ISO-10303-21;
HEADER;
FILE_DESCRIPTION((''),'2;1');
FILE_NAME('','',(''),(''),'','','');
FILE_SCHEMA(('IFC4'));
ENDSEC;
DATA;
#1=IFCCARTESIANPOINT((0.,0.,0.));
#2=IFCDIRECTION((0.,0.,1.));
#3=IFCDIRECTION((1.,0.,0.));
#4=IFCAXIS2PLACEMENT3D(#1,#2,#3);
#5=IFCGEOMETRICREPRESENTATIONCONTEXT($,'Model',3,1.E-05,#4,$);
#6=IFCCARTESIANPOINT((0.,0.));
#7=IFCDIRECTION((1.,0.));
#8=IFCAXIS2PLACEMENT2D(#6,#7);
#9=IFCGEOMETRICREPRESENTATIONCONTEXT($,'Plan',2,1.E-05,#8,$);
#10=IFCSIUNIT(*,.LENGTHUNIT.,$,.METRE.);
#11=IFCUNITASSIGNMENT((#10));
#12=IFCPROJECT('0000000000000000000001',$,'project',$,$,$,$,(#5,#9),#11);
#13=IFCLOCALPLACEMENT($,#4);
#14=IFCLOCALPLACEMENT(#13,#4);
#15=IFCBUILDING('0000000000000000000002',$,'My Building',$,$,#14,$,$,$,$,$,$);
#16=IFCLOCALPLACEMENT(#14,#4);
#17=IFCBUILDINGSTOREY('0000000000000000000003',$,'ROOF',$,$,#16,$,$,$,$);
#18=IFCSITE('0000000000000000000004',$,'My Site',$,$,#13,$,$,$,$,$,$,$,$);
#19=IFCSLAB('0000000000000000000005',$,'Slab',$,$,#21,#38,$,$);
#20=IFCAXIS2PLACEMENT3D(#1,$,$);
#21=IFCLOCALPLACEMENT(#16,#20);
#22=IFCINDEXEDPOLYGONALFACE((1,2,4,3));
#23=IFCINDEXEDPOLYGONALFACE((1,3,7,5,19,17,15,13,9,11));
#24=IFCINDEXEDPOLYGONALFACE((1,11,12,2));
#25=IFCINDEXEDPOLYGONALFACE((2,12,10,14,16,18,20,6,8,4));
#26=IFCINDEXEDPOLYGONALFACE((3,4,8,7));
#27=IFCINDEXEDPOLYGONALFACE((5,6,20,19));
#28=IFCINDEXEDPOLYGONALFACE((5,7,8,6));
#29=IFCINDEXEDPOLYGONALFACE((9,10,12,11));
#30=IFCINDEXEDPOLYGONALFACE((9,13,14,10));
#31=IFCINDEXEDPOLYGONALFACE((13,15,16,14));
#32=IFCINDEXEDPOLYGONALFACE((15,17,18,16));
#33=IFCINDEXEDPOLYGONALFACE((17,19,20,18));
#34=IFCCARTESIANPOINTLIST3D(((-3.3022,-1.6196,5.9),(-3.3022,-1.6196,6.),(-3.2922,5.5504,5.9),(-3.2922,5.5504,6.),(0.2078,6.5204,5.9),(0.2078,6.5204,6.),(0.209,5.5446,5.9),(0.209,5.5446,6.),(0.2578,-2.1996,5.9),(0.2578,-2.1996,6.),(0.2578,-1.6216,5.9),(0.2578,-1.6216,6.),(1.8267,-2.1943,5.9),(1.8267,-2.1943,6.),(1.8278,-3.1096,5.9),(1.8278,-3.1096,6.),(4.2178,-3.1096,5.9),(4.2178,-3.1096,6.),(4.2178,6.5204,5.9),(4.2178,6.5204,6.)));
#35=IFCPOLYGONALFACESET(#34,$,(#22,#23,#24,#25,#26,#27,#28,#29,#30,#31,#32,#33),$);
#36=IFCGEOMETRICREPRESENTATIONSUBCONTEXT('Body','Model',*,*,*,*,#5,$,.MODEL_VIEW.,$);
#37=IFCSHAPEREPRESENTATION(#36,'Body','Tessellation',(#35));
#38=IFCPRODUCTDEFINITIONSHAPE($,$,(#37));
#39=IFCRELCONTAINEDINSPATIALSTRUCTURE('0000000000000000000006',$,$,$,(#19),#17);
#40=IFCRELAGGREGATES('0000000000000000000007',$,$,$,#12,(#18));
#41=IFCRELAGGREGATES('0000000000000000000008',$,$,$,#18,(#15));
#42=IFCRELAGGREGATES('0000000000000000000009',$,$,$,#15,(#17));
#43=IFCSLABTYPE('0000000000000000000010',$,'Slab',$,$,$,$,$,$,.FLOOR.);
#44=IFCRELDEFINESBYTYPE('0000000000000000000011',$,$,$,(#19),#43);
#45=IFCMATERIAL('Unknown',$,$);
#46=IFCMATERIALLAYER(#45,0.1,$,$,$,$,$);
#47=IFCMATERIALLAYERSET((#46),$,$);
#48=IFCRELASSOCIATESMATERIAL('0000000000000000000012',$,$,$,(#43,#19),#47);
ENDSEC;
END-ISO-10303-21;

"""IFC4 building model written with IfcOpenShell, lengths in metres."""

from ifc_helpers import new_model, si_unit, frame, origin_with_axes, origin_2d_with_axis, place, context, subcontext, project, spatial, indexed_curve, outline, extrude, material, layer, layer_set, layer_usage, type_object, element, save


model = new_model("IFC4")

# Units and contexts
model_context = context("Model", 3, precision=1e-05, world=origin_with_axes())
plan_context = context("Plan", 2, precision=1e-05, world=origin_2d_with_axis())
body_context = subcontext(model_context, "Body", "Model", "MODEL_VIEW")
ifc_project = project(units=[si_unit("LENGTHUNIT", "METRE")], contexts=[model_context, plan_context])

# Site, building, storey
site_placement = place(None, origin_with_axes())
site = spatial("IfcSite", under=ifc_project, at=site_placement, Name="My Site")
building_placement = place(site_placement, origin_with_axes())
building = spatial("IfcBuilding", under=site, at=building_placement, Name="My Building")
storey_placement = place(building_placement, origin_with_axes())
storey = spatial("IfcBuildingStorey", under=building, at=storey_placement, Name="ROOF")

# Slab
ifc_material = material(Name="Unknown")
ifc_layer = layer(ifc_material, 0.1)
ifc_layer_set = layer_set([ifc_layer])
ifc_layer_usage = layer_usage(ifc_layer_set, "AXIS3", "POSITIVE", -0.1)
slab_type = type_object("IfcSlabType", Name="Slab", PredefinedType="FLOOR", material=ifc_layer_set)
slab_placement = place(storey_placement, frame((-3.2922, 5.5504, 6.0), z_axis=(0.0, 0.0, 1.0), x_axis=(1.0, 0.0, 0.0)))
element("IfcSlab", 1, at=slab_placement, inside=storey, type_object=slab_type, material=ifc_layer_usage, Name="Slab", context=body_context, shape_type="SweptSolid", body=[
    extrude(outline(indexed_curve([(0.0, 0.0), (-0.01, -7.17), (3.55, -7.172), (3.55, -7.75), (5.1189, -7.7447), (5.12, -8.66), (7.51, -8.66), (7.51, 0.97), (3.5, 0.97), (3.5012, -0.0058), (0.0, 0.0)])), frame((0.0, 0.0, -0.1), z_axis=(0.0, 0.0, 1.0), x_axis=(1.0, 0.0, 0.0)), (0.0, 0.0, 1.0), 0.1),
])

save(model, "model.ifc")
